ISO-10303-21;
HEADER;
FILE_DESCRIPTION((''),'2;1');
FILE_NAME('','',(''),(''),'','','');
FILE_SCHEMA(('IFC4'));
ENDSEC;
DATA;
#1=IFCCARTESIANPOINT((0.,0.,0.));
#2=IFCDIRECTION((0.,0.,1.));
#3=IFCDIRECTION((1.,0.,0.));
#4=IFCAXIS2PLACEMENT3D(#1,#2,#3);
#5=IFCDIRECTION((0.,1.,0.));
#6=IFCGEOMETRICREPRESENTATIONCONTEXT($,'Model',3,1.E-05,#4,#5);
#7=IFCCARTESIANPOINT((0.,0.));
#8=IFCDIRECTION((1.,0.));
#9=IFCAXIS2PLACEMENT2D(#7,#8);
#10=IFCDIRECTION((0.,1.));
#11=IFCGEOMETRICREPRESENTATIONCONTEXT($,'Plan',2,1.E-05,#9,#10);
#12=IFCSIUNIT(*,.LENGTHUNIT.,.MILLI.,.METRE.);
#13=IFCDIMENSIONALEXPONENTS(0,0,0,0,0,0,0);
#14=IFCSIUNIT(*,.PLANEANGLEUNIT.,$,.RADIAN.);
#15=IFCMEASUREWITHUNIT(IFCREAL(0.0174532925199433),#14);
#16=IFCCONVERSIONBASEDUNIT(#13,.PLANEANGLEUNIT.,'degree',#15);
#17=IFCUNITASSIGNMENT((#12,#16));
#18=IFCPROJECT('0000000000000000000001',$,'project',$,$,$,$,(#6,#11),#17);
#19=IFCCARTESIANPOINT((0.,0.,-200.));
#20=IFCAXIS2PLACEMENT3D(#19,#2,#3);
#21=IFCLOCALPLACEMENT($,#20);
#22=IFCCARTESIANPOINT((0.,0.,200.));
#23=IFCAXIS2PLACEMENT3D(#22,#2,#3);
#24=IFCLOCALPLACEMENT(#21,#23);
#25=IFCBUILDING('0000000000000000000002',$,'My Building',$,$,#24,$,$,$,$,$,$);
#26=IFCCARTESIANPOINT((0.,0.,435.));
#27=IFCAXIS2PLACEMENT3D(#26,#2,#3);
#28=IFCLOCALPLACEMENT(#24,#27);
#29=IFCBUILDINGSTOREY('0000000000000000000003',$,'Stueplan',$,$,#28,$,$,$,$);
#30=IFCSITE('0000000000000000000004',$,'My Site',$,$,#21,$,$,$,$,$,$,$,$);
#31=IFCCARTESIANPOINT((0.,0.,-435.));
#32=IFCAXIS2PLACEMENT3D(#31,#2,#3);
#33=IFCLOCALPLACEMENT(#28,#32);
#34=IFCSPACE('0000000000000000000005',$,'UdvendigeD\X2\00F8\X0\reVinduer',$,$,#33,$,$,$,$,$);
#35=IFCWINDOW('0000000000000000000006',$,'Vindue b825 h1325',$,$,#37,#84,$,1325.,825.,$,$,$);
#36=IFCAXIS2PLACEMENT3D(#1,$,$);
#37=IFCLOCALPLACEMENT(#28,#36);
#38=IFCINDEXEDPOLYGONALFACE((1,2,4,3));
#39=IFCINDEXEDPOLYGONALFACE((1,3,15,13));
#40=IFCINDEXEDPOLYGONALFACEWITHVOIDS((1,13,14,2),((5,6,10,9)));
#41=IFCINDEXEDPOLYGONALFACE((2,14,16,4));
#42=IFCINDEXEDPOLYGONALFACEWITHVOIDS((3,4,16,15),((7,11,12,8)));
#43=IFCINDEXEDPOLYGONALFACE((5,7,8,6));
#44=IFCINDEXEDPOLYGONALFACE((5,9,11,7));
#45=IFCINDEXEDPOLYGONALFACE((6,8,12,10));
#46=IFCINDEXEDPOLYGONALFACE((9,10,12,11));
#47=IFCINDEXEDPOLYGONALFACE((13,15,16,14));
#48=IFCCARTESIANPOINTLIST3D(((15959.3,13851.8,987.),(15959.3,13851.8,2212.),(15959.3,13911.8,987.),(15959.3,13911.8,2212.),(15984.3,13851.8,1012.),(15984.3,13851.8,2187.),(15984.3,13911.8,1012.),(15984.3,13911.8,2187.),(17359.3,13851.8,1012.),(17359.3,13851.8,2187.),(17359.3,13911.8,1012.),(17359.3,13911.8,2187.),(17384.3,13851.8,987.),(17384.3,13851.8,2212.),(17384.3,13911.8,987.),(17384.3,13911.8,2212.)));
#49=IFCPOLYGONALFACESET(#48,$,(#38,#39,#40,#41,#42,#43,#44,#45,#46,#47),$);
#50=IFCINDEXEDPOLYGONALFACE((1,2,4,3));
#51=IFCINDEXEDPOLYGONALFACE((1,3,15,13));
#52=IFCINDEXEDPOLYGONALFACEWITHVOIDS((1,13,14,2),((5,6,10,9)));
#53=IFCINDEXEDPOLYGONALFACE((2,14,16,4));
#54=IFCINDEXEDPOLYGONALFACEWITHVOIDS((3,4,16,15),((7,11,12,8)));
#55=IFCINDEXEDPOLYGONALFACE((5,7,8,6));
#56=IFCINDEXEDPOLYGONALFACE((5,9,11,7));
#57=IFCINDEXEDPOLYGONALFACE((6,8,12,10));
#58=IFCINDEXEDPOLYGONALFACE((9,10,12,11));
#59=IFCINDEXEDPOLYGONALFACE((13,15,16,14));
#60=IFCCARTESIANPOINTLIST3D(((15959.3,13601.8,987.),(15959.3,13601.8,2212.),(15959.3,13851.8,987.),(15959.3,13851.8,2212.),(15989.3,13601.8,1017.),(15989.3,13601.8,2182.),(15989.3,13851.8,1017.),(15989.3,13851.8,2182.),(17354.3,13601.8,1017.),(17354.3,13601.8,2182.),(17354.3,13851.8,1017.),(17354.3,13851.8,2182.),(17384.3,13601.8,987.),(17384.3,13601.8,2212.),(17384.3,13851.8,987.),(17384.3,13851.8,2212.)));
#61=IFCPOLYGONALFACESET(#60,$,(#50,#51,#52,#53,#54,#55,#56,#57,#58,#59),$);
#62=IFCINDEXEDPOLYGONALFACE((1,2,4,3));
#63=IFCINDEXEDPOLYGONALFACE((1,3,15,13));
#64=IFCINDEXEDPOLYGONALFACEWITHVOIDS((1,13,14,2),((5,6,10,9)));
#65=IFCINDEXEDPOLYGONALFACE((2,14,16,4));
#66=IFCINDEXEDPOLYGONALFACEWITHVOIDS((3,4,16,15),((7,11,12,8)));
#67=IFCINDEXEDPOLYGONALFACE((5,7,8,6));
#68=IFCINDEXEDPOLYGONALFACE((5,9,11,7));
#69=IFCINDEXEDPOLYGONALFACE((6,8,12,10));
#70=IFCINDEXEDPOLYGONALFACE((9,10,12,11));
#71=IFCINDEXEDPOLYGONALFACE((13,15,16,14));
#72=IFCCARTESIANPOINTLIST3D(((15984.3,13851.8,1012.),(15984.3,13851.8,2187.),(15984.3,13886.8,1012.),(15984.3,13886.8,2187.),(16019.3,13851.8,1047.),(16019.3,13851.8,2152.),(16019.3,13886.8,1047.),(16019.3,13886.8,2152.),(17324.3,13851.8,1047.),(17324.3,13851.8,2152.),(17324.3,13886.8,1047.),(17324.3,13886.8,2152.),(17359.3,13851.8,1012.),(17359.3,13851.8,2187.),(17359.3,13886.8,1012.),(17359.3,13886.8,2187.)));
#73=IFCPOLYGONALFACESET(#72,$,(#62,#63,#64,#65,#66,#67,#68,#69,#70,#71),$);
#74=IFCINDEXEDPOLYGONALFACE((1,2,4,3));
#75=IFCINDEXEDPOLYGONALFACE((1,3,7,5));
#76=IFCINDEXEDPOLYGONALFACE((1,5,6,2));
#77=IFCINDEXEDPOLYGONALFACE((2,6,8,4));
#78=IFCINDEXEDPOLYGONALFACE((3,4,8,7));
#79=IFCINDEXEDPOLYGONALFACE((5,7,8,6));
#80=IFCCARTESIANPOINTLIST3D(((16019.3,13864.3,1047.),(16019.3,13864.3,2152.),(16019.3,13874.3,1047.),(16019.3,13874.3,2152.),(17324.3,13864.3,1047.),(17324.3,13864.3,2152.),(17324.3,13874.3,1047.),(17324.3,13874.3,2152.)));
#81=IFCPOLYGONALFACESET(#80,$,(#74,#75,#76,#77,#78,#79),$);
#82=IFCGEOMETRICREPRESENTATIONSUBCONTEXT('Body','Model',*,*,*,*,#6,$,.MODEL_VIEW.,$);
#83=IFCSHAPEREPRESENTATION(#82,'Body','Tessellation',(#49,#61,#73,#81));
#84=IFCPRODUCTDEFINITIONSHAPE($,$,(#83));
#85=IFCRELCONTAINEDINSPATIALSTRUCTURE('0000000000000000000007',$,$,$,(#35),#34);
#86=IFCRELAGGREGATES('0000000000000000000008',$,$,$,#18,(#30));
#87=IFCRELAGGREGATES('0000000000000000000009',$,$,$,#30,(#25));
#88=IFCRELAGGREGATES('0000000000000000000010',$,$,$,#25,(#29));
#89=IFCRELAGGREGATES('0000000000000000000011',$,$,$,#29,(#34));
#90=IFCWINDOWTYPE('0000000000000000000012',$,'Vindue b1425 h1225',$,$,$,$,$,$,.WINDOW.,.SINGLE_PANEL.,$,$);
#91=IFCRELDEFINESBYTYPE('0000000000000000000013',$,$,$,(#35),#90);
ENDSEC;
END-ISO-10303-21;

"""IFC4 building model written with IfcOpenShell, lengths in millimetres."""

from ifc_helpers import new_model, entity, si_unit, converted_unit, direction, frame, origin_with_axes, origin_2d_with_axis, place, context, subcontext, project, spatial, line, indexed_curve, outline, extrude, shape, source, transform, mapped, type_object, type_shapes, element, save


model = new_model("IFC4")

# Units and contexts
model_context = context("Model", 3, precision=1e-05, world=origin_with_axes(), true_north=direction((0.0, 1.0, 0.0)))
plan_context = context("Plan", 2, precision=1e-05, world=origin_2d_with_axis(), true_north=direction((0.0, 1.0)))
body_context_1 = subcontext(model_context, "Body", "Model", "MODEL_VIEW")
body_context_2 = subcontext(plan_context, "Body", "Plan", "PLAN_VIEW")
ifc_project = project(units=[si_unit("LENGTHUNIT", "METRE", prefix="MILLI"), converted_unit("PLANEANGLEUNIT", "degree", entity("IfcReal", 0.0174532925199433), si_unit("PLANEANGLEUNIT", "RADIAN"), dimensions=[0, 0, 0, 0, 0, 0, 0])], contexts=[model_context, plan_context])

# Site, building, storey
site_placement = place(None, frame((0.0, 0.0, -200.0), z_axis=(0.0, 0.0, 1.0), x_axis=(1.0, 0.0, 0.0)))
site = spatial("IfcSite", under=ifc_project, at=site_placement, Name="My Site")
building_placement = place(site_placement, frame((0.0, 0.0, 200.0), z_axis=(0.0, 0.0, 1.0), x_axis=(1.0, 0.0, 0.0)))
building = spatial("IfcBuilding", under=site, at=building_placement, Name="My Building")
storey_placement = place(building_placement, frame((0.0, 0.0, 435.0), z_axis=(0.0, 0.0, 1.0), x_axis=(1.0, 0.0, 0.0)))
storey = spatial("IfcBuildingStorey", under=building, at=storey_placement, Name="Stueplan")

# Shared definitions
space_1_placement = place(storey_placement, frame((0.0, 0.0, -435.0), z_axis=(0.0, 0.0, 1.0), x_axis=(1.0, 0.0, 0.0)))
space_1 = spatial("IfcSpace", under=storey, at=space_1_placement, Name="UdvendigeDøreVinduer")

# Window
window_type = type_object("IfcWindowType", Name="Vindue b1425 h1225", PartitioningType="SINGLE_PANEL", PredefinedType="WINDOW")
shared_shape_1 = source(origin_with_axes(), body_context_1, "Body", "SweptSolid", [
    extrude(outline(indexed_curve([(0.0, 0.0), (1425.0, 0.0), (1425.0, 1225.0), (0.0, 1225.0)], segments=[line(1, 2, 3, 4, 1)]), holes=[indexed_curve([(25.0, 25.0), (1400.0, 25.0), (1400.0, 1200.0), (25.0, 1200.0)], segments=[line(1, 2, 3, 4, 1)])]), frame((0.0, 250.0, 0.0), z_axis=(0.0, -1.0, 0.0), x_axis=(1.0, 0.0, 0.0)), (0.0, 0.0, -1.0), 60.0),
    extrude(outline(indexed_curve([(0.0, 0.0), (1425.0, 0.0), (1425.0, 1225.0), (0.0, 1225.0)], segments=[line(1, 2, 3, 4, 1)]), holes=[indexed_curve([(30.0, 30.0), (1395.0, 30.0), (1395.0, 1195.0), (30.0, 1195.0)], segments=[line(1, 2, 3, 4, 1)])]), frame((0.0, 0.0, 0.0), z_axis=(0.0, -1.0, 0.0), x_axis=(1.0, 0.0, 0.0)), (0.0, 0.0, -1.0), 250.0),
    extrude(outline(indexed_curve([(0.0, 0.0), (1375.0, 0.0), (1375.0, 1175.0), (0.0, 1175.0)], segments=[line(1, 2, 3, 4, 1)]), holes=[indexed_curve([(35.0, 35.0), (1340.0, 35.0), (1340.0, 1140.0), (35.0, 1140.0)], segments=[line(1, 2, 3, 4, 1)])]), frame((25.0, 250.0, 25.0), z_axis=(0.0, -1.0, 0.0), x_axis=(1.0, 0.0, 0.0)), (0.0, 0.0, -1.0), 35.0),
    extrude(outline(indexed_curve([(35.0, 35.0), (1340.0, 35.0), (1340.0, 1140.0), (35.0, 1140.0)], segments=[line(1, 2, 3, 4, 1)])), frame((25.0, 262.5, 25.0), z_axis=(0.0, -1.0, 0.0), x_axis=(1.0, 0.0, 0.0)), (0.0, 0.0, -1.0), 10.0),
])
shared_shape_2 = source(origin_with_axes(), body_context_2, "Body", "Curve2D", [
    entity("IfcIndexedPolyCurve", entity("IfcCartesianPointList2D", [[30.0, 0.0], [1395.0, 0.0]])),
    entity("IfcIndexedPolyCurve", entity("IfcCartesianPointList2D", [[0.0, 310.0], [25.0, 310.0], [25.0, 250.0], [30.0, 250.0], [30.0, 0.0], [0.0, 0.0]]), [entity("IfcLineIndex", [1, 2, 3, 4, 5, 6, 1])]),
    entity("IfcIndexedPolyCurve", entity("IfcCartesianPointList2D", [[1425.0, 310.0], [1400.0, 310.0], [1400.0, 250.0], [1395.0, 250.0], [1395.0, 0.0], [1425.0, 0.0]]), [entity("IfcLineIndex", [1, 2, 3, 4, 5, 6, 1])]),
    entity("IfcIndexedPolyCurve", entity("IfcCartesianPointList2D", [[25.0, 250.0], [60.0, 250.0], [60.0, 285.0], [25.0, 285.0]]), [entity("IfcLineIndex", [1, 2, 3, 4, 1])]),
    entity("IfcIndexedPolyCurve", entity("IfcCartesianPointList2D", [[1400.0, 250.0], [1365.0, 250.0], [1365.0, 285.0], [1400.0, 285.0]]), [entity("IfcLineIndex", [1, 2, 3, 4, 1])]),
    entity("IfcIndexedPolyCurve", entity("IfcCartesianPointList2D", [[60.0, 250.0], [1365.0, 250.0]])),
    entity("IfcIndexedPolyCurve", entity("IfcCartesianPointList2D", [[60.0, 285.0], [1365.0, 285.0]])),
    entity("IfcIndexedPolyCurve", entity("IfcCartesianPointList2D", [[60.0, 267.5], [1365.0, 267.5]])),
])
type_shapes(window_type, [shared_shape_1, shared_shape_2])
window_placement = place(space_1_placement, frame((15959.3, 13601.8, 1422.0), z_axis=(0.0, 0.0, 1.0), x_axis=(1.0, 0.0, 0.0)))
element("IfcWindow", 1, at=window_placement, inside=space_1, type_object=window_type, Name="Vindue b825 h1325", OverallHeight=1325.0, OverallWidth=825.0, shapes=[
    shape(body_context_1, "Body", "MappedRepresentation", [mapped(shared_shape_1, transform((0.0, 0.0, 0.0), x_axis=(1.0, 0.0, 0.0), y_axis=(0.0, 1.0, 0.0), z_axis=(0.0, 0.0, 1.0), scale=1.0))]),
    shape(body_context_2, "Body", "MappedRepresentation", [mapped(shared_shape_2, transform((0.0, 0.0, 0.0), x_axis=(1.0, 0.0, 0.0), y_axis=(0.0, 1.0, 0.0), z_axis=(0.0, 0.0, 1.0), scale=1.0))]),
])

save(model, "model.ifc")
